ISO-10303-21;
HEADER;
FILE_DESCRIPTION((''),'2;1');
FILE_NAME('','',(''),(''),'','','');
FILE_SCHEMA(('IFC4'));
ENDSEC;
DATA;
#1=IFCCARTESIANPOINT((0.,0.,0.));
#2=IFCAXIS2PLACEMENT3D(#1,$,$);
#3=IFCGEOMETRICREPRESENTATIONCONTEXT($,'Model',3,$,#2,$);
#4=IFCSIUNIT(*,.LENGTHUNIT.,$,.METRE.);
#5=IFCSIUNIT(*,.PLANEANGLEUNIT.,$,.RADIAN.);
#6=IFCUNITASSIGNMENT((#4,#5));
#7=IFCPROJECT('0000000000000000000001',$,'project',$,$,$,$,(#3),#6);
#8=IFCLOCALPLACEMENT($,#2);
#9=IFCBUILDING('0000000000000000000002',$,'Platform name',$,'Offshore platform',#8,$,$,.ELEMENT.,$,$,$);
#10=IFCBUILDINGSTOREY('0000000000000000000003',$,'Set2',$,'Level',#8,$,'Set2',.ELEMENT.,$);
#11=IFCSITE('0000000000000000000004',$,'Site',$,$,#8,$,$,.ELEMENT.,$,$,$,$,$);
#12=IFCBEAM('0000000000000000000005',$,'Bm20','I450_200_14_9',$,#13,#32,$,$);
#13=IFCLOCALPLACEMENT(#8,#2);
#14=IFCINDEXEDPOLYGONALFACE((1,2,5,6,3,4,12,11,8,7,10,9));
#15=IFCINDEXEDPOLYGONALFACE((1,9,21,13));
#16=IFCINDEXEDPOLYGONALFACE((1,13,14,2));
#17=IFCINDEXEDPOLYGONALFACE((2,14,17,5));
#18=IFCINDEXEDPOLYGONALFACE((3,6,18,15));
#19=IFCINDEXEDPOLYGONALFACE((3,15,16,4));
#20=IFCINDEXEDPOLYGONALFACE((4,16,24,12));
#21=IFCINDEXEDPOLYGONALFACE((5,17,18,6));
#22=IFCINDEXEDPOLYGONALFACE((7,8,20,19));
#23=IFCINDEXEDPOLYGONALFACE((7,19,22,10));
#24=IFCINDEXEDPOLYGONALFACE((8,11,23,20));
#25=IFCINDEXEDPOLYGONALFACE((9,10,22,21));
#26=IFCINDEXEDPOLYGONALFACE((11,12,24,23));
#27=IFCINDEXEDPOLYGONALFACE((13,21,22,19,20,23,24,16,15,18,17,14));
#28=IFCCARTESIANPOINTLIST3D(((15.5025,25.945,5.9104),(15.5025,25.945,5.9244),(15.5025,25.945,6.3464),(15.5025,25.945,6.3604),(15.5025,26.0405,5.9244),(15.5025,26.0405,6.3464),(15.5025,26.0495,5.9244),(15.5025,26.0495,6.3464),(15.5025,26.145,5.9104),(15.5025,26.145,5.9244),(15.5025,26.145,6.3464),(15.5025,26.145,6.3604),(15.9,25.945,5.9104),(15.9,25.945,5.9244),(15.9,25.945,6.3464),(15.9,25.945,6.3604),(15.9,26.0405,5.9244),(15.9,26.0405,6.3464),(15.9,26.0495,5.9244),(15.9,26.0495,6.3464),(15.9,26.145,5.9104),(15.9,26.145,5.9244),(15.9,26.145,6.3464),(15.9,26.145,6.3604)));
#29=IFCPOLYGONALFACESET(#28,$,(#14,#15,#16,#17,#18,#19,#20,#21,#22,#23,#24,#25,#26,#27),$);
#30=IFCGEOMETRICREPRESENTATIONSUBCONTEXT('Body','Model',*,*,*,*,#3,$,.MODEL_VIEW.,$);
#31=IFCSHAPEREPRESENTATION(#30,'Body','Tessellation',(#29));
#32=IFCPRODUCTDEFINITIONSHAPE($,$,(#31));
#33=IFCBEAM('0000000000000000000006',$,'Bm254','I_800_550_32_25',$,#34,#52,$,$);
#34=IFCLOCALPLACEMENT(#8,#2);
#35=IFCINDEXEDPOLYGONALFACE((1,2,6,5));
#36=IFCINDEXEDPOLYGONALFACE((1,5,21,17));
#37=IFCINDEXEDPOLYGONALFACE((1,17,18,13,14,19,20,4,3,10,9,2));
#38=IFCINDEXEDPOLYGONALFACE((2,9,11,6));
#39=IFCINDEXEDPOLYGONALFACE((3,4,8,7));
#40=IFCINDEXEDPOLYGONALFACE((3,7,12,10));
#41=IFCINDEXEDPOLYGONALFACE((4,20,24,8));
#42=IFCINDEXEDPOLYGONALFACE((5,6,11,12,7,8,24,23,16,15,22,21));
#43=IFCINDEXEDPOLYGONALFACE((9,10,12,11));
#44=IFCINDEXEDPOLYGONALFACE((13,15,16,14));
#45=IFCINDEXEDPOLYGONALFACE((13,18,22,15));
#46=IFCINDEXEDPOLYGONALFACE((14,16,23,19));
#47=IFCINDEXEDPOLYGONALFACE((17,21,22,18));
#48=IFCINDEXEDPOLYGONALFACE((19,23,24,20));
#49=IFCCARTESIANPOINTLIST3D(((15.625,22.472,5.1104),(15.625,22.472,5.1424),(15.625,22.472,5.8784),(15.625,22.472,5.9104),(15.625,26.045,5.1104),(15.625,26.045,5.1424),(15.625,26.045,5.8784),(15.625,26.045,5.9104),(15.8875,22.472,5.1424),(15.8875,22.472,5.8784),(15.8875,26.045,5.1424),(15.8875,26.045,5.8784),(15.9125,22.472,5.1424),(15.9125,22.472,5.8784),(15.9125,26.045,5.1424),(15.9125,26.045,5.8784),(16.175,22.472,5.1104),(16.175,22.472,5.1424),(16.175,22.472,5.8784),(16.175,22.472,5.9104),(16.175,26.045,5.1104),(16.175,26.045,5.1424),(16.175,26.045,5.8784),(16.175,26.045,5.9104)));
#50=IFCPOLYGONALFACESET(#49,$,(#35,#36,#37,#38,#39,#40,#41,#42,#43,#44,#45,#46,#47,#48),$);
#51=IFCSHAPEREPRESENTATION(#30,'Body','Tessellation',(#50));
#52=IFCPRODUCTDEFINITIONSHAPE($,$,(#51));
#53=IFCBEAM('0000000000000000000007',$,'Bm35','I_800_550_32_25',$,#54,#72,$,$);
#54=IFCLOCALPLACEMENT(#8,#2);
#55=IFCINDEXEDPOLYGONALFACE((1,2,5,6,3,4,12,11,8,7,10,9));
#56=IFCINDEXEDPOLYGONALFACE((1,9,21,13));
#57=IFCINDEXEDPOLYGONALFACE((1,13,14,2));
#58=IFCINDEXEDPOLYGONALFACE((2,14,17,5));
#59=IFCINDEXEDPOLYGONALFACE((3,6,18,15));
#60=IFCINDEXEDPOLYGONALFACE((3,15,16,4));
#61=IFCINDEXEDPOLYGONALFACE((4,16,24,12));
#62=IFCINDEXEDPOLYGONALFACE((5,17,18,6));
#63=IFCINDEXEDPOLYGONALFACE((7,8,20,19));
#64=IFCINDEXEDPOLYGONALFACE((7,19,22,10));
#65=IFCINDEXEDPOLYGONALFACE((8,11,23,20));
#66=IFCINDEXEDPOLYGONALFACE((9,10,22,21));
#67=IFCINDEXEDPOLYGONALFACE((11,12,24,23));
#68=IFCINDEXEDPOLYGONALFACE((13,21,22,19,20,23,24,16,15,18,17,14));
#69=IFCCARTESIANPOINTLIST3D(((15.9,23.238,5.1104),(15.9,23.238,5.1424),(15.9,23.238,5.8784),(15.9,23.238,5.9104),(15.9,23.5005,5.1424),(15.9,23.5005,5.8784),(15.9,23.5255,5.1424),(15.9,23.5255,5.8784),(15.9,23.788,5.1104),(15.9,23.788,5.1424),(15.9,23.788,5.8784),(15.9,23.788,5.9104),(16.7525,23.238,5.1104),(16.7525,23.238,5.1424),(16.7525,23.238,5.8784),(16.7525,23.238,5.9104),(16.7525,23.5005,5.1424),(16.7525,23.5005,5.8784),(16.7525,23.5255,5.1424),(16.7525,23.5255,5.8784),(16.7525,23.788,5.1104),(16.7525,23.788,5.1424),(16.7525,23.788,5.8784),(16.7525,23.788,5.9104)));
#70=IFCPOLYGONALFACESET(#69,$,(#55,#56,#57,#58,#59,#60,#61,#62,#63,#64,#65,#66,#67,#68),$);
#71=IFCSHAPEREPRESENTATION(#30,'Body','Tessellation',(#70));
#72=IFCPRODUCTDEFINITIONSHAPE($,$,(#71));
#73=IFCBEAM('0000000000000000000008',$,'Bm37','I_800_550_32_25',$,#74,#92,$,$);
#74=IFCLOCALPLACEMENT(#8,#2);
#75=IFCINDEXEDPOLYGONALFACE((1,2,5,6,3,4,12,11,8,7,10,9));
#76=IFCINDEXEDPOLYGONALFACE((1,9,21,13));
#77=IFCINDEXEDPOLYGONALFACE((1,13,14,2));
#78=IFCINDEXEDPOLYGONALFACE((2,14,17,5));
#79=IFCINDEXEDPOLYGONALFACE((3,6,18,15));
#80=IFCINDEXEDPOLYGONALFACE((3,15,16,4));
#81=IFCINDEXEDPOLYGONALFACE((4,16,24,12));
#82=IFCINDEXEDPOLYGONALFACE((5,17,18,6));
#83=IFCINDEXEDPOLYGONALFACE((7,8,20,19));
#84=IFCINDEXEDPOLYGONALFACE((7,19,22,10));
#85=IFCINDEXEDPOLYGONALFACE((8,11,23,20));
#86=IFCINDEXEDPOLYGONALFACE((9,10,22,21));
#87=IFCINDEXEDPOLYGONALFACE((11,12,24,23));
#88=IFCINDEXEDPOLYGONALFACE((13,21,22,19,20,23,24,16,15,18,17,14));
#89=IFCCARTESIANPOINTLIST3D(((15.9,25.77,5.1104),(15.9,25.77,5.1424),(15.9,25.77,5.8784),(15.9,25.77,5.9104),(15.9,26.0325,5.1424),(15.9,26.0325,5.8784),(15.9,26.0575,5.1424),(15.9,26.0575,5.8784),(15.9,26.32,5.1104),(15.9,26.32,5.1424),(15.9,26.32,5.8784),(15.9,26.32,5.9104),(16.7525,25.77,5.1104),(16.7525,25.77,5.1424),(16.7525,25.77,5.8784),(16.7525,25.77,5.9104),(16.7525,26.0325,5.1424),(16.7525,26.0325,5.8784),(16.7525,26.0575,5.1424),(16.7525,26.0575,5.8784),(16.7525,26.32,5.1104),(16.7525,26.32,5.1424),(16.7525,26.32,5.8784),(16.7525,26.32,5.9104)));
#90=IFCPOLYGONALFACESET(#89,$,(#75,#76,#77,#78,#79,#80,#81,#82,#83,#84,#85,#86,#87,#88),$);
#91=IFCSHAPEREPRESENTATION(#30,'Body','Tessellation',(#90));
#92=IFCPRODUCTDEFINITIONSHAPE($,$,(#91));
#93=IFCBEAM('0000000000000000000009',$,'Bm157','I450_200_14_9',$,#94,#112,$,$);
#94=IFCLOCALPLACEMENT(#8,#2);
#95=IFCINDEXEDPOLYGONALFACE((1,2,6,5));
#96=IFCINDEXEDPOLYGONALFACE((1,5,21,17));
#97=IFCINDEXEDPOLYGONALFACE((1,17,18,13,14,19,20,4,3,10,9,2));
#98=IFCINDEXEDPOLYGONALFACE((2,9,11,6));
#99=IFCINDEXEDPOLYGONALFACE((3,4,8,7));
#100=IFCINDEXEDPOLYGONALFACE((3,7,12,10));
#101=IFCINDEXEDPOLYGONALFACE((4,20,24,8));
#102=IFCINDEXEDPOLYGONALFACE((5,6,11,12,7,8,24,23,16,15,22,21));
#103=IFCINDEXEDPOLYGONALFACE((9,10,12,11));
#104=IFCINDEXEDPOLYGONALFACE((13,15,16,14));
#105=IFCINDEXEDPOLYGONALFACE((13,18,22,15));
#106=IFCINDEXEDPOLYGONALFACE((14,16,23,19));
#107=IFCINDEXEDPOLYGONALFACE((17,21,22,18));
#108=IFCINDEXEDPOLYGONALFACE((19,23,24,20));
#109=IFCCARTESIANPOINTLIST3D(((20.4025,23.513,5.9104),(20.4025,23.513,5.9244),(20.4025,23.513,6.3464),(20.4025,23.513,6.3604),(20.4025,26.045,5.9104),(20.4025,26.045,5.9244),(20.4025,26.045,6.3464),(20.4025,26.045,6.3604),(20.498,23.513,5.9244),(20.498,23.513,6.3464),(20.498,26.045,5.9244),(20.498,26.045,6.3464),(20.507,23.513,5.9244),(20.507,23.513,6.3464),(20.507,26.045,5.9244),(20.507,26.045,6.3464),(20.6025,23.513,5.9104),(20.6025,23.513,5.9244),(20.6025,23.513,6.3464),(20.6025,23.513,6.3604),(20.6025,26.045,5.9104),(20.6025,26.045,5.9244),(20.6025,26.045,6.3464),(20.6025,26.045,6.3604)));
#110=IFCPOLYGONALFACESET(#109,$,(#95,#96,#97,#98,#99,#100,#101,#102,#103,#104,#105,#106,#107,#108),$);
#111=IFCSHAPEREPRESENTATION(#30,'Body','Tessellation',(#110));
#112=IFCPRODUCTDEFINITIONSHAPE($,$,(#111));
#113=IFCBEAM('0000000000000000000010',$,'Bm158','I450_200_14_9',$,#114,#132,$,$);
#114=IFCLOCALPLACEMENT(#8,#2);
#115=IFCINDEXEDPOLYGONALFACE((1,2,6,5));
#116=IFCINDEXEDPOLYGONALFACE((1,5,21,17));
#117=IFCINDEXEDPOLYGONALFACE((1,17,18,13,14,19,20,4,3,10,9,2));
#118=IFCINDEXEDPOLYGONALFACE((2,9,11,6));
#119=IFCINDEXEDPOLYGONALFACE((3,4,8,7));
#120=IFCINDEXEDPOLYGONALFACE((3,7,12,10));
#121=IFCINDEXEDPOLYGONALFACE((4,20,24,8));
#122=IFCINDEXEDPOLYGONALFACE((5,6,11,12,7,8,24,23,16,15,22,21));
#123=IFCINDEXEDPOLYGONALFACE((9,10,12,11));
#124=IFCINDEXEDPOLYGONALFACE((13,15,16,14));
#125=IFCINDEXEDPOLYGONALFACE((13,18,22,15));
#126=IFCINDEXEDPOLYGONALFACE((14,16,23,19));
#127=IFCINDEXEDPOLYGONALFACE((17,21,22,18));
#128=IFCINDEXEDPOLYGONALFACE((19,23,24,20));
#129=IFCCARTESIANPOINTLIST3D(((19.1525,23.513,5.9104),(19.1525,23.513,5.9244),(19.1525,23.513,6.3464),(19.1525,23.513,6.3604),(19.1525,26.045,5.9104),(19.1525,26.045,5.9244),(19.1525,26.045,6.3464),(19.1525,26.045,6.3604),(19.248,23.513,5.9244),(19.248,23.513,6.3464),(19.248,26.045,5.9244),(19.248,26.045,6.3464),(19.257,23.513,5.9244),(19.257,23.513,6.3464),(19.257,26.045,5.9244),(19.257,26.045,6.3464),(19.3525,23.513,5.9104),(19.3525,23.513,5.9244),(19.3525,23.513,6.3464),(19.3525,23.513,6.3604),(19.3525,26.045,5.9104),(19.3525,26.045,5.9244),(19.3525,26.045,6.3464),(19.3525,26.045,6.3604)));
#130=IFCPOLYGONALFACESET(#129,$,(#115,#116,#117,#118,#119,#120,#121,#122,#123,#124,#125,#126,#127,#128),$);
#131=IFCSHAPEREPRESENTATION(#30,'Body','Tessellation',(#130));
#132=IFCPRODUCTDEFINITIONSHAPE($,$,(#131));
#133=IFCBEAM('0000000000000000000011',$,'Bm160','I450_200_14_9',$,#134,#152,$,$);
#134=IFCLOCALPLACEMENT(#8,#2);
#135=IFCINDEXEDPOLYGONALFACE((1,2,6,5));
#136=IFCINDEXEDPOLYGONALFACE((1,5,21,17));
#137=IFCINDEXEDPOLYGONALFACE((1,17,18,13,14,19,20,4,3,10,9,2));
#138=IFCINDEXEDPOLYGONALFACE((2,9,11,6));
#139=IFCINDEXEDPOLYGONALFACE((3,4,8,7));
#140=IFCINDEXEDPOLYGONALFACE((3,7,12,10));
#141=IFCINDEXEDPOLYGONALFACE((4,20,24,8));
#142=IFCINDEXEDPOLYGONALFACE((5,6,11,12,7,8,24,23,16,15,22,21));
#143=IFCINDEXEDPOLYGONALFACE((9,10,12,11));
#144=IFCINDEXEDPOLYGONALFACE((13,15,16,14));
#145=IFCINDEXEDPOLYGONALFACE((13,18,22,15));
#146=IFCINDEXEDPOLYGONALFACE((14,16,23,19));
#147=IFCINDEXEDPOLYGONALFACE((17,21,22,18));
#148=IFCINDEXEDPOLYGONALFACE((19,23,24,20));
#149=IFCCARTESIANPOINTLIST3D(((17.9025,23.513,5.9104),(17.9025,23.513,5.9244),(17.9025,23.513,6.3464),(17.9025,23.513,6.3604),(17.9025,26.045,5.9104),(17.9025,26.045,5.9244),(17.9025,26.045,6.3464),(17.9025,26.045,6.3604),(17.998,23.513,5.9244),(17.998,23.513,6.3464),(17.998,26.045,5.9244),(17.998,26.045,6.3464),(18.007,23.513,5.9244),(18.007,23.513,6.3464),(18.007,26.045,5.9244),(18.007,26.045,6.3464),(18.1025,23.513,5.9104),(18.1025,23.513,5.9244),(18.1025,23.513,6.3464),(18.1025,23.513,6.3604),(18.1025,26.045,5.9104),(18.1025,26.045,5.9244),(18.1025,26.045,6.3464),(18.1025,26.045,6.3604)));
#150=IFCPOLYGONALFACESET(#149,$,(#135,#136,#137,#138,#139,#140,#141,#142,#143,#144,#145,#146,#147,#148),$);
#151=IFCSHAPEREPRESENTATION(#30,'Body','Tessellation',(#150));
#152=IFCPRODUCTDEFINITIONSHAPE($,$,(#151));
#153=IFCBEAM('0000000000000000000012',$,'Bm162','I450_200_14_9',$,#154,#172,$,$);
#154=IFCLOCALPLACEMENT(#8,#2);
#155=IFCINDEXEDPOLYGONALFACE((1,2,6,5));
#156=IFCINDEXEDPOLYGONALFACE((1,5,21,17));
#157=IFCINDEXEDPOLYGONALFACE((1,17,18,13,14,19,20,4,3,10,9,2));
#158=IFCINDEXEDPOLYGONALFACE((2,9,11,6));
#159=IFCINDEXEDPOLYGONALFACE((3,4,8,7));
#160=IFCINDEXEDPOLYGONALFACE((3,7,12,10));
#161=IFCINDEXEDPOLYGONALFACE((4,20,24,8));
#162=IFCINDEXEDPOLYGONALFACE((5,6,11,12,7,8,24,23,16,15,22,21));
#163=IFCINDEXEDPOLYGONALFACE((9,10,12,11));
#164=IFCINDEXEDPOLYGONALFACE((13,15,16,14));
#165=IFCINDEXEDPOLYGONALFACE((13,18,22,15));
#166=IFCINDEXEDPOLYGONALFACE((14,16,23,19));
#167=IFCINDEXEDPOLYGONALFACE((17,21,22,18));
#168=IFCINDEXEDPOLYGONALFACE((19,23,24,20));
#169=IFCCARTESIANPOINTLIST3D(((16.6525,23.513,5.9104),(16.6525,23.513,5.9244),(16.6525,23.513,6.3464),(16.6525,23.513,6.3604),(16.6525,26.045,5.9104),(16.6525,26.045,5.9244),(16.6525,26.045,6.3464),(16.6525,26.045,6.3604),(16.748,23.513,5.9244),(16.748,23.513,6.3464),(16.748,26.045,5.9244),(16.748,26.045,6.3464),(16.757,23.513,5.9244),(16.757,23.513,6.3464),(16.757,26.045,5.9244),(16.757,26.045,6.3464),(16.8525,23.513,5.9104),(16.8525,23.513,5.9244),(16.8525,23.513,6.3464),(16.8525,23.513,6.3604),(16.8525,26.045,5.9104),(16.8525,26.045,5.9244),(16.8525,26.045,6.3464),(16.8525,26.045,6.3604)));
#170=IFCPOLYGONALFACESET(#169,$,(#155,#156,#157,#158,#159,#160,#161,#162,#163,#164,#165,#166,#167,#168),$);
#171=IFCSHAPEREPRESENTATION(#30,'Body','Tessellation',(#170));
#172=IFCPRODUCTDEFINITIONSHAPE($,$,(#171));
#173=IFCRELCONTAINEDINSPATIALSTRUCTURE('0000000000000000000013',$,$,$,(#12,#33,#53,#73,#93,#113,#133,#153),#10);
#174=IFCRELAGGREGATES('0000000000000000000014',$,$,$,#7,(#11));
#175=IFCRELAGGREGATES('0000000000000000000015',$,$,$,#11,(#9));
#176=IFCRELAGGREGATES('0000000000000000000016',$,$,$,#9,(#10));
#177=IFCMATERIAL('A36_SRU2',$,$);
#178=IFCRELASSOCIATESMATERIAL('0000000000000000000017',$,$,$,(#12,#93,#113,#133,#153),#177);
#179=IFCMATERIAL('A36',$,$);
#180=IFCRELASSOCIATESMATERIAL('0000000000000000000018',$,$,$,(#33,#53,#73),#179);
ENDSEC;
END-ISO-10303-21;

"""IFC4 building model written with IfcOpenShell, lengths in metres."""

from ifc_helpers import new_model, si_unit, frame, origin, origin_2d, place, context, subcontext, project, spatial, i_section, extrude, source, transform, mapped, material, element, save


model = new_model("IFC4")

# Units and contexts
model_context = context("Model", 3, world=origin())
body_context = subcontext(model_context, "Body", "Model", "MODEL_VIEW")
ifc_project = project(units=[si_unit("LENGTHUNIT", "METRE"), si_unit("PLANEANGLEUNIT", "RADIAN")], contexts=[model_context])

# Site, building, storey
placement_1 = place(None, origin())
site = spatial("IfcSite", under=ifc_project, at=placement_1, Name="Site", CompositionType="ELEMENT")
building = spatial("IfcBuilding", under=site, at=placement_1, Name="Platform name", ObjectType="Offshore platform", CompositionType="ELEMENT")
storey = spatial("IfcBuildingStorey", under=building, at=placement_1, Name="Set2", ObjectType="Level", LongName="Set2", CompositionType="ELEMENT")

# Beams
ifc_material_1 = material(Name="A36_SRU2")
shared_shape_1 = source(origin(), body_context, "Body", "SweptSolid", [
    extrude(i_section(OverallWidth=0.2, OverallDepth=0.45, WebThickness=0.009, FlangeThickness=0.014, FilletRadius=0.0, at=origin_2d()), frame((0.0, 0.0, 0.0), z_axis=(-1.0, 0.0, 0.0), x_axis=(0.0, -1.0, 0.0)), (0.0, 0.0, 1.0), 0.3975),
])
placement_2 = place(None, origin())
placement_3 = place(placement_2, origin())
placement_4 = place(placement_3, origin())
beam_1_placement = place(placement_4, frame((15.9, 26.045, 6.1354)))
element("IfcBeam", 1, at=beam_1_placement, inside=storey, material=ifc_material_1, Name="Bm20", Description="I450_200_14_9", context=body_context, shape_type="MappedRepresentation", body=[
    mapped(shared_shape_1, transform((0.0, 0.0, 0.0), scale=1.0)),
])
ifc_material_2 = material(Name="A36")
shared_shape_2 = source(origin(), body_context, "Body", "SweptSolid", [
    extrude(i_section(OverallWidth=0.55, OverallDepth=0.8, WebThickness=0.025, FlangeThickness=0.032, FilletRadius=0.0, at=origin_2d()), frame((0.0, 0.0, 0.0), z_axis=(0.0, -1.0, 0.0), x_axis=(1.0, 0.0, 0.0)), (0.0, 0.0, 1.0), 3.573),
])
placement_5 = place(None, origin())
placement_6 = place(placement_5, origin())
placement_7 = place(placement_6, origin())
beam_2_placement = place(placement_7, frame((15.9, 26.045, 5.5104)))
element("IfcBeam", 2, at=beam_2_placement, inside=storey, material=ifc_material_2, Name="Bm254", Description="I_800_550_32_25", context=body_context, shape_type="MappedRepresentation", body=[
    mapped(shared_shape_2, transform((0.0, 0.0, 0.0), scale=1.0)),
])
shared_shape_3 = source(origin(), body_context, "Body", "SweptSolid", [
    extrude(i_section(OverallWidth=0.55, OverallDepth=0.8, WebThickness=0.025, FlangeThickness=0.032, FilletRadius=0.0, at=origin_2d()), frame((0.0, 0.0, 0.0), z_axis=(1.0, 0.0, 0.0), x_axis=(0.0, 1.0, 0.0)), (0.0, 0.0, 1.0), 0.8525),
])
placement_8 = place(None, origin())
placement_9 = place(placement_8, origin())
placement_10 = place(placement_9, origin())
beam_3_placement = place(placement_10, frame((15.9, 23.513, 5.5104)))
element("IfcBeam", 3, at=beam_3_placement, inside=storey, material=ifc_material_2, Name="Bm35", Description="I_800_550_32_25", context=body_context, shape_type="MappedRepresentation", body=[
    mapped(shared_shape_3, transform((0.0, 0.0, 0.0), scale=1.0)),
])
shared_shape_4 = source(origin(), body_context, "Body", "SweptSolid", [
    extrude(i_section(OverallWidth=0.55, OverallDepth=0.8, WebThickness=0.025, FlangeThickness=0.032, FilletRadius=0.0, at=origin_2d()), frame((0.0, 0.0, 0.0), z_axis=(1.0, 0.0, 0.0), x_axis=(0.0, 1.0, 0.0)), (0.0, 0.0, 1.0), 0.8525),
])
placement_11 = place(None, origin())
placement_12 = place(placement_11, origin())
placement_13 = place(placement_12, origin())
beam_4_placement = place(placement_13, frame((15.9, 26.045, 5.5104)))
element("IfcBeam", 4, at=beam_4_placement, inside=storey, material=ifc_material_2, Name="Bm37", Description="I_800_550_32_25", context=body_context, shape_type="MappedRepresentation", body=[
    mapped(shared_shape_4, transform((0.0, 0.0, 0.0), scale=1.0)),
])
shared_shape_5 = source(origin(), body_context, "Body", "SweptSolid", [
    extrude(i_section(OverallWidth=0.2, OverallDepth=0.45, WebThickness=0.009, FlangeThickness=0.014, FilletRadius=0.0, at=origin_2d()), frame((0.0, 0.0, 0.0), z_axis=(0.0, 1.0, 0.0), x_axis=(-1.0, 0.0, 0.0)), (0.0, 0.0, 1.0), 2.532),
])
placement_14 = place(None, origin())
placement_15 = place(placement_14, origin())
placement_16 = place(placement_15, origin())
beam_5_placement = place(placement_16, frame((20.5025, 23.513, 6.1354)))
element("IfcBeam", 5, at=beam_5_placement, inside=storey, material=ifc_material_1, Name="Bm157", Description="I450_200_14_9", context=body_context, shape_type="MappedRepresentation", body=[
    mapped(shared_shape_5, transform((0.0, 0.0, 0.0), scale=1.0)),
])
shared_shape_6 = source(origin(), body_context, "Body", "SweptSolid", [
    extrude(i_section(OverallWidth=0.2, OverallDepth=0.45, WebThickness=0.009, FlangeThickness=0.014, FilletRadius=0.0, at=origin_2d()), frame((0.0, 0.0, 0.0), z_axis=(0.0, 1.0, 0.0), x_axis=(-1.0, 0.0, 0.0)), (0.0, 0.0, 1.0), 2.532),
])
placement_17 = place(None, origin())
placement_18 = place(placement_17, origin())
placement_19 = place(placement_18, origin())
beam_6_placement = place(placement_19, frame((19.2525, 23.513, 6.1354)))
element("IfcBeam", 6, at=beam_6_placement, inside=storey, material=ifc_material_1, Name="Bm158", Description="I450_200_14_9", context=body_context, shape_type="MappedRepresentation", body=[
    mapped(shared_shape_6, transform((0.0, 0.0, 0.0), scale=1.0)),
])
shared_shape_7 = source(origin(), body_context, "Body", "SweptSolid", [
    extrude(i_section(OverallWidth=0.2, OverallDepth=0.45, WebThickness=0.009, FlangeThickness=0.014, FilletRadius=0.0, at=origin_2d()), frame((0.0, 0.0, 0.0), z_axis=(0.0, 1.0, 0.0), x_axis=(-1.0, 0.0, 0.0)), (0.0, 0.0, 1.0), 2.532),
])
placement_20 = place(None, origin())
placement_21 = place(placement_20, origin())
placement_22 = place(placement_21, origin())
beam_7_placement = place(placement_22, frame((18.0025, 23.513, 6.1354)))
element("IfcBeam", 7, at=beam_7_placement, inside=storey, material=ifc_material_1, Name="Bm160", Description="I450_200_14_9", context=body_context, shape_type="MappedRepresentation", body=[
    mapped(shared_shape_7, transform((0.0, 0.0, 0.0), scale=1.0)),
])
shared_shape_8 = source(origin(), body_context, "Body", "SweptSolid", [
    extrude(i_section(OverallWidth=0.2, OverallDepth=0.45, WebThickness=0.009, FlangeThickness=0.014, FilletRadius=0.0, at=origin_2d()), frame((0.0, 0.0, 0.0), z_axis=(0.0, 1.0, 0.0), x_axis=(-1.0, 0.0, 0.0)), (0.0, 0.0, 1.0), 2.532),
])
placement_23 = place(None, origin())
placement_24 = place(placement_23, origin())
placement_25 = place(placement_24, origin())
beam_8_placement = place(placement_25, frame((16.7525, 23.513, 6.1354)))
element("IfcBeam", 8, at=beam_8_placement, inside=storey, material=ifc_material_1, Name="Bm162", Description="I450_200_14_9", context=body_context, shape_type="MappedRepresentation", body=[
    mapped(shared_shape_8, transform((0.0, 0.0, 0.0), scale=1.0)),
])

save(model, "model.ifc")
